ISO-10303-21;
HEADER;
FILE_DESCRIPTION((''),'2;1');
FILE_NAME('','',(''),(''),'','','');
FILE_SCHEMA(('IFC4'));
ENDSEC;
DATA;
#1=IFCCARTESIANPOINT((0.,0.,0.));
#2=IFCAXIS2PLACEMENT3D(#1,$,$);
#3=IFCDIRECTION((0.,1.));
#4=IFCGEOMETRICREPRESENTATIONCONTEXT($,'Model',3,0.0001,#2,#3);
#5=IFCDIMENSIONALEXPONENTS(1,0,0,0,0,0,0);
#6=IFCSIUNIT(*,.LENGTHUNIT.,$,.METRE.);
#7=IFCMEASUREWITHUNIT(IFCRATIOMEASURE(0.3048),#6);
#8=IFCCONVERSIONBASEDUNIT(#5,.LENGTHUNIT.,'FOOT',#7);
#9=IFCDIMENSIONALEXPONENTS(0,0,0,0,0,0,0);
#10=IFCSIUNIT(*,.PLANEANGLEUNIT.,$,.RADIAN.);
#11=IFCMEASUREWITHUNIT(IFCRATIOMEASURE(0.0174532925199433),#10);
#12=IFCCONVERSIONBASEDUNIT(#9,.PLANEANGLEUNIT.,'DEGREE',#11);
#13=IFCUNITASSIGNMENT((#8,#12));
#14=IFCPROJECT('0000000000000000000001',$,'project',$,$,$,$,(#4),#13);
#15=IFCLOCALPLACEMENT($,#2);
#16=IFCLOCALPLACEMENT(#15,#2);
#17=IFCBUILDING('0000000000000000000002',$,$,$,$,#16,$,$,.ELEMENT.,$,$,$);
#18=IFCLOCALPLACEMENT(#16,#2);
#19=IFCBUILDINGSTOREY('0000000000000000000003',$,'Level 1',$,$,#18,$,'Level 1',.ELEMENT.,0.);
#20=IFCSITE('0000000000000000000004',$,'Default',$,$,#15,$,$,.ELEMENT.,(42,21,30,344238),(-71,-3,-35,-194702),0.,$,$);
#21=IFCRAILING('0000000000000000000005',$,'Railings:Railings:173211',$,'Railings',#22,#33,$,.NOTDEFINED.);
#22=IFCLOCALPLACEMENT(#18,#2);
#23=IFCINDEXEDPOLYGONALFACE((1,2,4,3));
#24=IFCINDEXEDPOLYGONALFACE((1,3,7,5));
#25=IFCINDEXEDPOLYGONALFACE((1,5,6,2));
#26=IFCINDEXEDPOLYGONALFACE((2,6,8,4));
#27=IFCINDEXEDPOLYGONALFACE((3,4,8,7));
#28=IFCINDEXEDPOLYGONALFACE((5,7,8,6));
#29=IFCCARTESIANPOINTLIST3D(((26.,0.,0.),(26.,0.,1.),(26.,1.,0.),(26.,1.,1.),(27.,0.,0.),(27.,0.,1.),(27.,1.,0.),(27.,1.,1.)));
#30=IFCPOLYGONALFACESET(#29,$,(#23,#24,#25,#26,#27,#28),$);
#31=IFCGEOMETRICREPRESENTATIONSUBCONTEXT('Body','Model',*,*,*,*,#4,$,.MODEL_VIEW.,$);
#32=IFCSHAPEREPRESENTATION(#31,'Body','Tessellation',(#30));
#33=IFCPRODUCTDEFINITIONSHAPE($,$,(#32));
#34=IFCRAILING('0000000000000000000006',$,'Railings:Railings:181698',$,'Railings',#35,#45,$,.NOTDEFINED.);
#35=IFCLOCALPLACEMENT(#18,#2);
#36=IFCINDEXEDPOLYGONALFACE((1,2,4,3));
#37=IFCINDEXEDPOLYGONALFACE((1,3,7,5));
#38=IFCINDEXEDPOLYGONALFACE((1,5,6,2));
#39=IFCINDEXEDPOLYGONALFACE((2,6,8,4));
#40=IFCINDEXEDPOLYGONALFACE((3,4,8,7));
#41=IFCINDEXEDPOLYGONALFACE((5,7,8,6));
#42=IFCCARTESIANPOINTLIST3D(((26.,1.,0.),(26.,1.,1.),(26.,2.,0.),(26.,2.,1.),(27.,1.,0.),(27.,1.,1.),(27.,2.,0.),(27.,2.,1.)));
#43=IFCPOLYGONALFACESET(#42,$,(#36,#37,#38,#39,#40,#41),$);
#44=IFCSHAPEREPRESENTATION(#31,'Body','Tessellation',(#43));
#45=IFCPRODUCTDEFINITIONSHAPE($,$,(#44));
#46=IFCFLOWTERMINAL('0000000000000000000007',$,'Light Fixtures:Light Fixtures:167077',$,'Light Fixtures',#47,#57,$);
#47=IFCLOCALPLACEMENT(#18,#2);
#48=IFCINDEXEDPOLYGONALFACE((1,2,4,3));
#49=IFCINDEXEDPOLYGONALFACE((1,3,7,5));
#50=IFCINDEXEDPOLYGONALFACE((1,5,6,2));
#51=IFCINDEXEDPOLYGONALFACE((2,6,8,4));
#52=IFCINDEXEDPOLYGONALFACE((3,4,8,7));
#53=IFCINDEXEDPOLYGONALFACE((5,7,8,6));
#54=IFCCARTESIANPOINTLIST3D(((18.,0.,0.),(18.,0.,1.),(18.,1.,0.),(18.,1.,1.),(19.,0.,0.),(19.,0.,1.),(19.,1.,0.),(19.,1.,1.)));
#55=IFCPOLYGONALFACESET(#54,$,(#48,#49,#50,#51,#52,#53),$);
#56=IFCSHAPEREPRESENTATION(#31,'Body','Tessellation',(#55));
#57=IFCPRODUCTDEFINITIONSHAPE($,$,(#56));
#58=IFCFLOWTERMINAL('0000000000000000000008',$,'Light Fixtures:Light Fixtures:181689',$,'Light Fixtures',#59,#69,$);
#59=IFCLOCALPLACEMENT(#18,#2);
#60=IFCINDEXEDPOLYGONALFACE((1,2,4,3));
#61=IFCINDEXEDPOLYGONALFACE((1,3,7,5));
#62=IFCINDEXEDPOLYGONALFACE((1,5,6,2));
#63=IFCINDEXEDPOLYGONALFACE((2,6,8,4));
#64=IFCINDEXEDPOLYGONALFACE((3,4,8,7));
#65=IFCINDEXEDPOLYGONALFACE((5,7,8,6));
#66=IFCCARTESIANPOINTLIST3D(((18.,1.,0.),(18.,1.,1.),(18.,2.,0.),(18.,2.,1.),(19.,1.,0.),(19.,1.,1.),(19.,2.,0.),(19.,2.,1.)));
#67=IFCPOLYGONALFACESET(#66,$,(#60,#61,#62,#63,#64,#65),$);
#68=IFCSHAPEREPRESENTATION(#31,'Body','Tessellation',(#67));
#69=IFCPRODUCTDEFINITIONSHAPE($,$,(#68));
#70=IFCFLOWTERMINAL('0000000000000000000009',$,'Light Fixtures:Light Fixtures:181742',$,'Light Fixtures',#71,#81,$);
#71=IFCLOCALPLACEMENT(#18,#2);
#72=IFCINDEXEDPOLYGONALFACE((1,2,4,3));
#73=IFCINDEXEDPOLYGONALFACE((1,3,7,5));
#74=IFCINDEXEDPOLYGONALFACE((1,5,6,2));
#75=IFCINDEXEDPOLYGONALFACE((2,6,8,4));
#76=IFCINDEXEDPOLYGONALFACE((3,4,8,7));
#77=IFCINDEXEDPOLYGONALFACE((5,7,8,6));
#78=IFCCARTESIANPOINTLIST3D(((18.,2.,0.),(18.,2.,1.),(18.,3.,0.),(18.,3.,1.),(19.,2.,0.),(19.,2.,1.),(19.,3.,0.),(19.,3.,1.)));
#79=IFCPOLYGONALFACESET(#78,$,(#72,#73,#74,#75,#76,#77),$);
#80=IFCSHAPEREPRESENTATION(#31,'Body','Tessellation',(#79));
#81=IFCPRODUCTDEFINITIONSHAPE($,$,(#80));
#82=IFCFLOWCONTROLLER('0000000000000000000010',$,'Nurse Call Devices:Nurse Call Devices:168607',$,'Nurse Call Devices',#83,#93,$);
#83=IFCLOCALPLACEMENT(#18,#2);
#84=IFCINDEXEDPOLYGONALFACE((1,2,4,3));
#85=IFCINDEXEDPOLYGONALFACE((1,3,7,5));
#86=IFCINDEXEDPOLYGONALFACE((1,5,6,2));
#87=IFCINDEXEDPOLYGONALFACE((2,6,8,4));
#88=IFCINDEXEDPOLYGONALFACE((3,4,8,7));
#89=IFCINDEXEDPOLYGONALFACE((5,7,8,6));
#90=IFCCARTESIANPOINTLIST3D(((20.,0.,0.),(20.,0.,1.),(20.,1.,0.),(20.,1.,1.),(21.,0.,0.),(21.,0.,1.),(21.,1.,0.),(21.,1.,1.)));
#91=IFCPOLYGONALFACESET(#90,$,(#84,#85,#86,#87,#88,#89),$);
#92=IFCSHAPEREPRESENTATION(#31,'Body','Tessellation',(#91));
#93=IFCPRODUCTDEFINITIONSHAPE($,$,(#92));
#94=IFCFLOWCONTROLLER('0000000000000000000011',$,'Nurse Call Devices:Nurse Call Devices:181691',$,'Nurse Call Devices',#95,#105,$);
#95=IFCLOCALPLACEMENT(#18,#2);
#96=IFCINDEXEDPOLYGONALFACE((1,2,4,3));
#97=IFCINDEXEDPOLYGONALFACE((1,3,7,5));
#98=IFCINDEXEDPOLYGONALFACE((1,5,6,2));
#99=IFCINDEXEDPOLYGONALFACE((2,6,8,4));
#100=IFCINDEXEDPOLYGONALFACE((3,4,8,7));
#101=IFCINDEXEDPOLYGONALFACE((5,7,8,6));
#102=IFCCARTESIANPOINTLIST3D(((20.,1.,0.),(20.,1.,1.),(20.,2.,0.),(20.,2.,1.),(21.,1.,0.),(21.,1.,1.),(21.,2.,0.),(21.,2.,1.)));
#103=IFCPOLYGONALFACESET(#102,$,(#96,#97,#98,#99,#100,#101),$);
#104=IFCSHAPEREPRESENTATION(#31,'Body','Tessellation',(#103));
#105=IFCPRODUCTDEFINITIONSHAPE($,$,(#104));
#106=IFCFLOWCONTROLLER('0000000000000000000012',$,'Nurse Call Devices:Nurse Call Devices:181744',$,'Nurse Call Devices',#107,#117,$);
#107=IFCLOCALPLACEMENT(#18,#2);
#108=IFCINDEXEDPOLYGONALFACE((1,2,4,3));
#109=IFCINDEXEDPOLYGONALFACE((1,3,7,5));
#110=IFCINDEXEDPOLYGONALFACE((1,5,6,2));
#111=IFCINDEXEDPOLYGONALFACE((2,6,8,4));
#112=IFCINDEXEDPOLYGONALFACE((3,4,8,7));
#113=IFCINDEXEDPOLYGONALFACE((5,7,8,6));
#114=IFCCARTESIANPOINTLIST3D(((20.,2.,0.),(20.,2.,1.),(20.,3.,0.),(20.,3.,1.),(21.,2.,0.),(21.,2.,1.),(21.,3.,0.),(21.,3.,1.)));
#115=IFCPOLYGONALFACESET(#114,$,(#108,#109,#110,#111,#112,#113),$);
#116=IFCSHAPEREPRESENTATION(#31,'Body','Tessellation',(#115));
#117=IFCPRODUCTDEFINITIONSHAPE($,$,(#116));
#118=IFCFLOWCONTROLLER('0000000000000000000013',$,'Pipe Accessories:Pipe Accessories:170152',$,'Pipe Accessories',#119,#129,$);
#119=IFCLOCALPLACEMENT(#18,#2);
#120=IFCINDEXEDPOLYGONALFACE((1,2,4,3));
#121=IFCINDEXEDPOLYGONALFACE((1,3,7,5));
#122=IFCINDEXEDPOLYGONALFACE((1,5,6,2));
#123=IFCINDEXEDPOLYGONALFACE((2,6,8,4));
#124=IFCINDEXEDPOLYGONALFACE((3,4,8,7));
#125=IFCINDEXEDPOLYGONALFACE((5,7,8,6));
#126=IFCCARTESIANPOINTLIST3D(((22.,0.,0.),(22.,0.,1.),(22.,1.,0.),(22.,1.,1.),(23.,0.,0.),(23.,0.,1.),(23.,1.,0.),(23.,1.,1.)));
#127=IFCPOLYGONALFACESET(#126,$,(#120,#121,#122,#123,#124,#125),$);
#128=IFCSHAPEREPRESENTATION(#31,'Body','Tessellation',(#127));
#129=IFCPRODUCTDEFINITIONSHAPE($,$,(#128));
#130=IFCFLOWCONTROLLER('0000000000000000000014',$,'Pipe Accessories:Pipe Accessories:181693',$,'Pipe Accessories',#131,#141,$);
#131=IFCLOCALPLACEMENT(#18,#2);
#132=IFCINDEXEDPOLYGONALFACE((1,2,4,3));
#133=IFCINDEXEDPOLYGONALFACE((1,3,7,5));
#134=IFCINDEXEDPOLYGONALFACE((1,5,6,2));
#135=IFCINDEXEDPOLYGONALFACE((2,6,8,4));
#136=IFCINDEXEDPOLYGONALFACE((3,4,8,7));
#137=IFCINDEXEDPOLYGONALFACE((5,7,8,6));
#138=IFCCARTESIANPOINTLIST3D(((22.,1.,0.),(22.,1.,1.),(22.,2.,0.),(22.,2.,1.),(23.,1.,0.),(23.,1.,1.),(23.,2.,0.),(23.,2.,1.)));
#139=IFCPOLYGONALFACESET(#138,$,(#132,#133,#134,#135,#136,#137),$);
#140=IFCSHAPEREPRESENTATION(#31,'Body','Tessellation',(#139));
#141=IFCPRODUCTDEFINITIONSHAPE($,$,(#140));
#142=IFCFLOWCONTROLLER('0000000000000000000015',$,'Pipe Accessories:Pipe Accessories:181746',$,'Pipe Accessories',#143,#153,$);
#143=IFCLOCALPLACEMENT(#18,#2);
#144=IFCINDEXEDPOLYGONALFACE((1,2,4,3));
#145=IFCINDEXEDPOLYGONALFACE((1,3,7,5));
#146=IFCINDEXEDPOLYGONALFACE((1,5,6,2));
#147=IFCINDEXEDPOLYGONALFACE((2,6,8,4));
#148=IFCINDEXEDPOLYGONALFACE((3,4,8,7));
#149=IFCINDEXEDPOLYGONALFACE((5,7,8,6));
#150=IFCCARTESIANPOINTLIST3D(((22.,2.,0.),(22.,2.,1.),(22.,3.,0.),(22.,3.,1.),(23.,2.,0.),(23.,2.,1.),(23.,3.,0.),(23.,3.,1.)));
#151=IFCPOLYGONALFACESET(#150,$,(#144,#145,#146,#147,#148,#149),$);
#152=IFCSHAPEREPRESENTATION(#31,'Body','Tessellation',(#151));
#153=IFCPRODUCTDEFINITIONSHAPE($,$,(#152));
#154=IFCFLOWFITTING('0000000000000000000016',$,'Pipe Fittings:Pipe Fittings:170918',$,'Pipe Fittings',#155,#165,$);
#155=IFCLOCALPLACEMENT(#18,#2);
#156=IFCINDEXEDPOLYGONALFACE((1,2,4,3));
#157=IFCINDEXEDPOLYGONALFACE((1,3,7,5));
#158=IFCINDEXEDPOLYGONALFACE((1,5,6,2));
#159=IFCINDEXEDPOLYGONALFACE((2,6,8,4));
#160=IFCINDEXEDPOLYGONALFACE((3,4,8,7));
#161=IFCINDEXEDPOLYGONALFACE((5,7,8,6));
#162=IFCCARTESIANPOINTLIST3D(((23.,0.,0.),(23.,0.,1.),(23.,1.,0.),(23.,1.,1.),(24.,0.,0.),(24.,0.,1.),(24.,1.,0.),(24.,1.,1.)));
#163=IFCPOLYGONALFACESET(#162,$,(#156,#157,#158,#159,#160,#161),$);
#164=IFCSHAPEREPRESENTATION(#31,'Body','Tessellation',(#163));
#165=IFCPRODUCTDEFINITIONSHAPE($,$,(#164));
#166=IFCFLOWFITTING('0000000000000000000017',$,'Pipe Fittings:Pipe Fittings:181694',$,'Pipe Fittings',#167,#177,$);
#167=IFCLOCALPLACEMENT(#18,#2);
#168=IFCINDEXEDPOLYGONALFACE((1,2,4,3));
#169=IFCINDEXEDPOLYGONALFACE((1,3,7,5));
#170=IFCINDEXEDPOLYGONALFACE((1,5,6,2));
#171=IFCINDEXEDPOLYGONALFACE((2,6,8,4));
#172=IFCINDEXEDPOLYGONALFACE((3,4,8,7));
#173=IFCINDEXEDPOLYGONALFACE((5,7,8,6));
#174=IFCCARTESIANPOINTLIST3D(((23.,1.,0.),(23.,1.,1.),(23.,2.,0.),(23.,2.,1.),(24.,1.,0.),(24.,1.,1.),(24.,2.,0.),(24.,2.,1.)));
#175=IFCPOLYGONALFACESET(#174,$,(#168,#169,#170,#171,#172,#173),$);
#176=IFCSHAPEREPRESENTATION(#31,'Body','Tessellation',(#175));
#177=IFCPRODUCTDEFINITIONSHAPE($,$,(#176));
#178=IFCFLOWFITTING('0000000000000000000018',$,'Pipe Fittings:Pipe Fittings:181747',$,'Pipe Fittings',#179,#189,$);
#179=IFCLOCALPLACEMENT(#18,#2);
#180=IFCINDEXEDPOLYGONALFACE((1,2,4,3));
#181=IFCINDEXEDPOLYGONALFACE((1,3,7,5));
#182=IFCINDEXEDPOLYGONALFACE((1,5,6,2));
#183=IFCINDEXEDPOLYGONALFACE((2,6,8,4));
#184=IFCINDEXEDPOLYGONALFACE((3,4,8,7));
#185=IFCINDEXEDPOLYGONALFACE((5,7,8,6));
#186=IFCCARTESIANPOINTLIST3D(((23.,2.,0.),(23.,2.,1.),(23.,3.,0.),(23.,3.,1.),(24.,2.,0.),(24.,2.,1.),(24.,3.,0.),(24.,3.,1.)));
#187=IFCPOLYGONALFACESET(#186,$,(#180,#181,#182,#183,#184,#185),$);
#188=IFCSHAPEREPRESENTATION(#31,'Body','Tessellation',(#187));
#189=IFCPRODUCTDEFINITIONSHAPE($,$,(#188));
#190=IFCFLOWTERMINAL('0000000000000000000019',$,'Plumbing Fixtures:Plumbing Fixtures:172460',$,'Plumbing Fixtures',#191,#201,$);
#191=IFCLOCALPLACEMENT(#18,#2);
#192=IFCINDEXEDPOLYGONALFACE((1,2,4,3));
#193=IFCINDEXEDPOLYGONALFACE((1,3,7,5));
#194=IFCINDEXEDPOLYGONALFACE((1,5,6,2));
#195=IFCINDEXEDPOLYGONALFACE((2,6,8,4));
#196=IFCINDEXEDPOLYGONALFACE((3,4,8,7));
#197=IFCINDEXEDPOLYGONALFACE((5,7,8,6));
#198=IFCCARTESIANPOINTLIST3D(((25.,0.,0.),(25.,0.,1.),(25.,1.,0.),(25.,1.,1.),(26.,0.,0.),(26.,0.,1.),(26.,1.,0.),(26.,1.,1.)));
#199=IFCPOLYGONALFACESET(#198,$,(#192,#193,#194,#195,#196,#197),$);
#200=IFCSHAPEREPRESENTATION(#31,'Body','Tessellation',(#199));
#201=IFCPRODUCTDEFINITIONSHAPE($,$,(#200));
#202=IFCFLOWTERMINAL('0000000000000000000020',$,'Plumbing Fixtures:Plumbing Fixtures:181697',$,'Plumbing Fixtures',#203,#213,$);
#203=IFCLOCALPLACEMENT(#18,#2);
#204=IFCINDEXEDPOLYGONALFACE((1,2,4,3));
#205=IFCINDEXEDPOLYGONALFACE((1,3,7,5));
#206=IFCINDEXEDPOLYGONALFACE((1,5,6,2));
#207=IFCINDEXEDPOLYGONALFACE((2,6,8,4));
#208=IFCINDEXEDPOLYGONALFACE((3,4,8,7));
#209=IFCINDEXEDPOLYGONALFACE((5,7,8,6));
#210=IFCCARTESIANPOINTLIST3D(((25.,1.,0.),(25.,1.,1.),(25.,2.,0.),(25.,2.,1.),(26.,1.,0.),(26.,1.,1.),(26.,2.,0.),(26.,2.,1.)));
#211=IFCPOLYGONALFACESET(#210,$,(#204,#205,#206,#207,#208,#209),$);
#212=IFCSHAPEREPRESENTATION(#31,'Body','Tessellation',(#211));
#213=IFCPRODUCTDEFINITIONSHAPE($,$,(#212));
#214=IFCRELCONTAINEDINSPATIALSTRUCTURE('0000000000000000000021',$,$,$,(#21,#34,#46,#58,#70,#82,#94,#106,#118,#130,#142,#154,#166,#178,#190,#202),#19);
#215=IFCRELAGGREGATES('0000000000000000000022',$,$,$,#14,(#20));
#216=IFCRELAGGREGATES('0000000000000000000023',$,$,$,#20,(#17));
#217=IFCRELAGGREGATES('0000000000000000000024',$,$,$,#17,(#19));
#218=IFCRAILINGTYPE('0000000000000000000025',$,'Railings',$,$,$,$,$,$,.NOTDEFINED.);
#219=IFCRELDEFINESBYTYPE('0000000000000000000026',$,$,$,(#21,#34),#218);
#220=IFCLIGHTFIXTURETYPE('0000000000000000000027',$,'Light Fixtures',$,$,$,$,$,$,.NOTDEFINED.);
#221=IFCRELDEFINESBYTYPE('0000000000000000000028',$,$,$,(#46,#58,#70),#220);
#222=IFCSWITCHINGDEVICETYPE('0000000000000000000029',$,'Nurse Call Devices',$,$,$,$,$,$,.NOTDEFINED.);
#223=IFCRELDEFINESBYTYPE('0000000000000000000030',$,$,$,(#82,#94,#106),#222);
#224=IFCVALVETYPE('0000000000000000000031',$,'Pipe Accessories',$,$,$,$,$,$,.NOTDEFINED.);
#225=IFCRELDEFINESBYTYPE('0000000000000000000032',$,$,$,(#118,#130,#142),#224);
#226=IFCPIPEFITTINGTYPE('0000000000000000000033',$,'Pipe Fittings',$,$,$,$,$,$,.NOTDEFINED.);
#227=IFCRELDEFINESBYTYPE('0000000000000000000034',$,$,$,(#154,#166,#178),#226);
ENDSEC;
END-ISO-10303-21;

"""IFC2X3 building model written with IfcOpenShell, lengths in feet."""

from ifc_helpers import new_model, entity, si_unit, converted_unit, direction, frame, frame_2d, origin, place, context, subcontext, project, spatial, rectangle, extrude, source, transform, mapped, type_object, type_shapes, element, save


model = new_model("IFC2X3")

# Units and contexts
model_context = context("Model", 3, precision=0.0001, world=origin(), true_north=direction((0.0, 1.0)))
body_context = subcontext(model_context, "Body", "Model", "MODEL_VIEW")
ifc_project = project(units=[converted_unit("LENGTHUNIT", "FOOT", entity("IfcRatioMeasure", 0.3048), si_unit("LENGTHUNIT", "METRE"), dimensions=[1, 0, 0, 0, 0, 0, 0]), converted_unit("PLANEANGLEUNIT", "DEGREE", entity("IfcRatioMeasure", 0.0174532925199433), si_unit("PLANEANGLEUNIT", "RADIAN"), dimensions=[0, 0, 0, 0, 0, 0, 0])], contexts=[model_context])

# Site, building, storey
site_placement = place(None, origin())
site = spatial("IfcSite", under=ifc_project, at=site_placement, Name="Default", CompositionType="ELEMENT", RefLatitude=(42, 21, 30, 344238), RefLongitude=(-71, -3, -35, -194702), RefElevation=0.0)
building_placement = place(site_placement, origin())
building = spatial("IfcBuilding", under=site, at=building_placement, CompositionType="ELEMENT")
storey_placement = place(building_placement, origin())
storey = spatial("IfcBuildingStorey", under=building, at=storey_placement, Name="Level 1", LongName="Level 1", CompositionType="ELEMENT", Elevation=0.0)

# Railings
railing_type = type_object("IfcRailingType", Name="Railings", PredefinedType="NOTDEFINED")
shared_shape_1 = source(origin(), body_context, "Body", "SweptSolid", [
    extrude(rectangle(XDim=1.0, YDim=1.0, at=frame_2d((0.0, 0.0), x_axis=(1.0, 0.0))), frame((0.5, 0.5, 0.0), z_axis=(0.0, 0.0, 1.0), x_axis=(0.0, 1.0, 0.0)), (0.0, 0.0, 1.0), 1.0),
])
type_shapes(railing_type, [shared_shape_1])
for number, where, name in (
    (1, (26.0, 0.0, 0.0), "Railings:Railings:173211"),
    (2, (26.0, 1.0, 0.0), "Railings:Railings:181698"),
):
    element("IfcRailing", number, at=place(storey_placement, frame(where)), inside=storey, type_object=railing_type, Name=name, ObjectType="Railings", PredefinedType="NOTDEFINED", context=body_context, shape_type="MappedRepresentation", body=[
        mapped(shared_shape_1, transform((0.0, 0.0, 0.0), scale=1.0)),
    ])

# Flow terminals
light_fixture_type = type_object("IfcLightFixtureType", Name="Light Fixtures", PredefinedType="NOTDEFINED")
shared_shape_2 = source(origin(), body_context, "Body", "SweptSolid", [
    extrude(rectangle(XDim=1.0, YDim=1.0, at=frame_2d((0.0, 0.0), x_axis=(1.0, 0.0))), frame((0.5, 0.5, 0.0), z_axis=(0.0, 0.0, 1.0), x_axis=(0.0, 1.0, 0.0)), (0.0, 0.0, 1.0), 1.0),
])
type_shapes(light_fixture_type, [shared_shape_2])
for number, where, name in (
    (3, (18.0, 0.0, 0.0), "Light Fixtures:Light Fixtures:167077"),
    (4, (18.0, 1.0, 0.0), "Light Fixtures:Light Fixtures:181689"),
    (5, (18.0, 2.0, 0.0), "Light Fixtures:Light Fixtures:181742"),
):
    element("IfcFlowTerminal", number, at=place(storey_placement, frame(where)), inside=storey, type_object=light_fixture_type, Name=name, ObjectType="Light Fixtures", context=body_context, shape_type="MappedRepresentation", body=[
        mapped(shared_shape_2, transform((0.0, 0.0, 0.0), scale=1.0)),
    ])

# Flow controllers
switching_device_type = type_object("IfcSwitchingDeviceType", Name="Nurse Call Devices", PredefinedType="NOTDEFINED")
shared_shape_3 = source(origin(), body_context, "Body", "SweptSolid", [
    extrude(rectangle(XDim=1.0, YDim=1.0, at=frame_2d((0.0, 0.0), x_axis=(1.0, 0.0))), frame((0.5, 0.5, 0.0), z_axis=(0.0, 0.0, 1.0), x_axis=(0.0, 1.0, 0.0)), (0.0, 0.0, 1.0), 1.0),
])
type_shapes(switching_device_type, [shared_shape_3])
for number, where, name in (
    (6, (20.0, 0.0, 0.0), "Nurse Call Devices:Nurse Call Devices:168607"),
    (7, (20.0, 1.0, 0.0), "Nurse Call Devices:Nurse Call Devices:181691"),
    (8, (20.0, 2.0, 0.0), "Nurse Call Devices:Nurse Call Devices:181744"),
):
    element("IfcFlowController", number, at=place(storey_placement, frame(where)), inside=storey, type_object=switching_device_type, Name=name, ObjectType="Nurse Call Devices", context=body_context, shape_type="MappedRepresentation", body=[
        mapped(shared_shape_3, transform((0.0, 0.0, 0.0), scale=1.0)),
    ])
valve_type = type_object("IfcValveType", Name="Pipe Accessories", PredefinedType="NOTDEFINED")
shared_shape_4 = source(origin(), body_context, "Body", "SweptSolid", [
    extrude(rectangle(XDim=1.0, YDim=1.0, at=frame_2d((0.0, 0.0), x_axis=(1.0, 0.0))), frame((0.5, 0.5, 0.0), z_axis=(0.0, 0.0, 1.0), x_axis=(0.0, 1.0, 0.0)), (0.0, 0.0, 1.0), 1.0),
])
type_shapes(valve_type, [shared_shape_4])
for number, where, name in (
    (9, (22.0, 0.0, 0.0), "Pipe Accessories:Pipe Accessories:170152"),
    (10, (22.0, 1.0, 0.0), "Pipe Accessories:Pipe Accessories:181693"),
    (11, (22.0, 2.0, 0.0), "Pipe Accessories:Pipe Accessories:181746"),
):
    element("IfcFlowController", number, at=place(storey_placement, frame(where)), inside=storey, type_object=valve_type, Name=name, ObjectType="Pipe Accessories", context=body_context, shape_type="MappedRepresentation", body=[
        mapped(shared_shape_4, transform((0.0, 0.0, 0.0), scale=1.0)),
    ])

# Flow fittings
pipe_fitting_type = type_object("IfcPipeFittingType", Name="Pipe Fittings", PredefinedType="NOTDEFINED")
shared_shape_5 = source(origin(), body_context, "Body", "SweptSolid", [
    extrude(rectangle(XDim=1.0, YDim=1.0, at=frame_2d((0.0, 0.0), x_axis=(1.0, 0.0))), frame((0.5, 0.5, 0.0), z_axis=(0.0, 0.0, 1.0), x_axis=(0.0, 1.0, 0.0)), (0.0, 0.0, 1.0), 1.0),
])
type_shapes(pipe_fitting_type, [shared_shape_5])
for number, where, name in (
    (12, (23.0, 0.0, 0.0), "Pipe Fittings:Pipe Fittings:170918"),
    (13, (23.0, 1.0, 0.0), "Pipe Fittings:Pipe Fittings:181694"),
    (14, (23.0, 2.0, 0.0), "Pipe Fittings:Pipe Fittings:181747"),
):
    element("IfcFlowFitting", number, at=place(storey_placement, frame(where)), inside=storey, type_object=pipe_fitting_type, Name=name, ObjectType="Pipe Fittings", context=body_context, shape_type="MappedRepresentation", body=[
        mapped(shared_shape_5, transform((0.0, 0.0, 0.0), scale=1.0)),
    ])

# Flow terminals
shared_shape_6 = source(origin(), body_context, "Body", "SweptSolid", [
    extrude(rectangle(XDim=1.0, YDim=1.0, at=frame_2d((0.0, 0.0), x_axis=(1.0, 0.0))), frame((0.5, 0.5, 0.0), z_axis=(0.0, 0.0, 1.0), x_axis=(0.0, 1.0, 0.0)), (0.0, 0.0, 1.0), 1.0),
])
for number, where, name in (
    (15, (25.0, 0.0, 0.0), "Plumbing Fixtures:Plumbing Fixtures:172460"),
    (16, (25.0, 1.0, 0.0), "Plumbing Fixtures:Plumbing Fixtures:181697"),
):
    element("IfcFlowTerminal", number, at=place(storey_placement, frame(where)), inside=storey, Name=name, ObjectType="Plumbing Fixtures", context=body_context, shape_type="MappedRepresentation", body=[
        mapped(shared_shape_6, transform((0.0, 0.0, 0.0), scale=1.0)),
    ])

save(model, "model.ifc")
